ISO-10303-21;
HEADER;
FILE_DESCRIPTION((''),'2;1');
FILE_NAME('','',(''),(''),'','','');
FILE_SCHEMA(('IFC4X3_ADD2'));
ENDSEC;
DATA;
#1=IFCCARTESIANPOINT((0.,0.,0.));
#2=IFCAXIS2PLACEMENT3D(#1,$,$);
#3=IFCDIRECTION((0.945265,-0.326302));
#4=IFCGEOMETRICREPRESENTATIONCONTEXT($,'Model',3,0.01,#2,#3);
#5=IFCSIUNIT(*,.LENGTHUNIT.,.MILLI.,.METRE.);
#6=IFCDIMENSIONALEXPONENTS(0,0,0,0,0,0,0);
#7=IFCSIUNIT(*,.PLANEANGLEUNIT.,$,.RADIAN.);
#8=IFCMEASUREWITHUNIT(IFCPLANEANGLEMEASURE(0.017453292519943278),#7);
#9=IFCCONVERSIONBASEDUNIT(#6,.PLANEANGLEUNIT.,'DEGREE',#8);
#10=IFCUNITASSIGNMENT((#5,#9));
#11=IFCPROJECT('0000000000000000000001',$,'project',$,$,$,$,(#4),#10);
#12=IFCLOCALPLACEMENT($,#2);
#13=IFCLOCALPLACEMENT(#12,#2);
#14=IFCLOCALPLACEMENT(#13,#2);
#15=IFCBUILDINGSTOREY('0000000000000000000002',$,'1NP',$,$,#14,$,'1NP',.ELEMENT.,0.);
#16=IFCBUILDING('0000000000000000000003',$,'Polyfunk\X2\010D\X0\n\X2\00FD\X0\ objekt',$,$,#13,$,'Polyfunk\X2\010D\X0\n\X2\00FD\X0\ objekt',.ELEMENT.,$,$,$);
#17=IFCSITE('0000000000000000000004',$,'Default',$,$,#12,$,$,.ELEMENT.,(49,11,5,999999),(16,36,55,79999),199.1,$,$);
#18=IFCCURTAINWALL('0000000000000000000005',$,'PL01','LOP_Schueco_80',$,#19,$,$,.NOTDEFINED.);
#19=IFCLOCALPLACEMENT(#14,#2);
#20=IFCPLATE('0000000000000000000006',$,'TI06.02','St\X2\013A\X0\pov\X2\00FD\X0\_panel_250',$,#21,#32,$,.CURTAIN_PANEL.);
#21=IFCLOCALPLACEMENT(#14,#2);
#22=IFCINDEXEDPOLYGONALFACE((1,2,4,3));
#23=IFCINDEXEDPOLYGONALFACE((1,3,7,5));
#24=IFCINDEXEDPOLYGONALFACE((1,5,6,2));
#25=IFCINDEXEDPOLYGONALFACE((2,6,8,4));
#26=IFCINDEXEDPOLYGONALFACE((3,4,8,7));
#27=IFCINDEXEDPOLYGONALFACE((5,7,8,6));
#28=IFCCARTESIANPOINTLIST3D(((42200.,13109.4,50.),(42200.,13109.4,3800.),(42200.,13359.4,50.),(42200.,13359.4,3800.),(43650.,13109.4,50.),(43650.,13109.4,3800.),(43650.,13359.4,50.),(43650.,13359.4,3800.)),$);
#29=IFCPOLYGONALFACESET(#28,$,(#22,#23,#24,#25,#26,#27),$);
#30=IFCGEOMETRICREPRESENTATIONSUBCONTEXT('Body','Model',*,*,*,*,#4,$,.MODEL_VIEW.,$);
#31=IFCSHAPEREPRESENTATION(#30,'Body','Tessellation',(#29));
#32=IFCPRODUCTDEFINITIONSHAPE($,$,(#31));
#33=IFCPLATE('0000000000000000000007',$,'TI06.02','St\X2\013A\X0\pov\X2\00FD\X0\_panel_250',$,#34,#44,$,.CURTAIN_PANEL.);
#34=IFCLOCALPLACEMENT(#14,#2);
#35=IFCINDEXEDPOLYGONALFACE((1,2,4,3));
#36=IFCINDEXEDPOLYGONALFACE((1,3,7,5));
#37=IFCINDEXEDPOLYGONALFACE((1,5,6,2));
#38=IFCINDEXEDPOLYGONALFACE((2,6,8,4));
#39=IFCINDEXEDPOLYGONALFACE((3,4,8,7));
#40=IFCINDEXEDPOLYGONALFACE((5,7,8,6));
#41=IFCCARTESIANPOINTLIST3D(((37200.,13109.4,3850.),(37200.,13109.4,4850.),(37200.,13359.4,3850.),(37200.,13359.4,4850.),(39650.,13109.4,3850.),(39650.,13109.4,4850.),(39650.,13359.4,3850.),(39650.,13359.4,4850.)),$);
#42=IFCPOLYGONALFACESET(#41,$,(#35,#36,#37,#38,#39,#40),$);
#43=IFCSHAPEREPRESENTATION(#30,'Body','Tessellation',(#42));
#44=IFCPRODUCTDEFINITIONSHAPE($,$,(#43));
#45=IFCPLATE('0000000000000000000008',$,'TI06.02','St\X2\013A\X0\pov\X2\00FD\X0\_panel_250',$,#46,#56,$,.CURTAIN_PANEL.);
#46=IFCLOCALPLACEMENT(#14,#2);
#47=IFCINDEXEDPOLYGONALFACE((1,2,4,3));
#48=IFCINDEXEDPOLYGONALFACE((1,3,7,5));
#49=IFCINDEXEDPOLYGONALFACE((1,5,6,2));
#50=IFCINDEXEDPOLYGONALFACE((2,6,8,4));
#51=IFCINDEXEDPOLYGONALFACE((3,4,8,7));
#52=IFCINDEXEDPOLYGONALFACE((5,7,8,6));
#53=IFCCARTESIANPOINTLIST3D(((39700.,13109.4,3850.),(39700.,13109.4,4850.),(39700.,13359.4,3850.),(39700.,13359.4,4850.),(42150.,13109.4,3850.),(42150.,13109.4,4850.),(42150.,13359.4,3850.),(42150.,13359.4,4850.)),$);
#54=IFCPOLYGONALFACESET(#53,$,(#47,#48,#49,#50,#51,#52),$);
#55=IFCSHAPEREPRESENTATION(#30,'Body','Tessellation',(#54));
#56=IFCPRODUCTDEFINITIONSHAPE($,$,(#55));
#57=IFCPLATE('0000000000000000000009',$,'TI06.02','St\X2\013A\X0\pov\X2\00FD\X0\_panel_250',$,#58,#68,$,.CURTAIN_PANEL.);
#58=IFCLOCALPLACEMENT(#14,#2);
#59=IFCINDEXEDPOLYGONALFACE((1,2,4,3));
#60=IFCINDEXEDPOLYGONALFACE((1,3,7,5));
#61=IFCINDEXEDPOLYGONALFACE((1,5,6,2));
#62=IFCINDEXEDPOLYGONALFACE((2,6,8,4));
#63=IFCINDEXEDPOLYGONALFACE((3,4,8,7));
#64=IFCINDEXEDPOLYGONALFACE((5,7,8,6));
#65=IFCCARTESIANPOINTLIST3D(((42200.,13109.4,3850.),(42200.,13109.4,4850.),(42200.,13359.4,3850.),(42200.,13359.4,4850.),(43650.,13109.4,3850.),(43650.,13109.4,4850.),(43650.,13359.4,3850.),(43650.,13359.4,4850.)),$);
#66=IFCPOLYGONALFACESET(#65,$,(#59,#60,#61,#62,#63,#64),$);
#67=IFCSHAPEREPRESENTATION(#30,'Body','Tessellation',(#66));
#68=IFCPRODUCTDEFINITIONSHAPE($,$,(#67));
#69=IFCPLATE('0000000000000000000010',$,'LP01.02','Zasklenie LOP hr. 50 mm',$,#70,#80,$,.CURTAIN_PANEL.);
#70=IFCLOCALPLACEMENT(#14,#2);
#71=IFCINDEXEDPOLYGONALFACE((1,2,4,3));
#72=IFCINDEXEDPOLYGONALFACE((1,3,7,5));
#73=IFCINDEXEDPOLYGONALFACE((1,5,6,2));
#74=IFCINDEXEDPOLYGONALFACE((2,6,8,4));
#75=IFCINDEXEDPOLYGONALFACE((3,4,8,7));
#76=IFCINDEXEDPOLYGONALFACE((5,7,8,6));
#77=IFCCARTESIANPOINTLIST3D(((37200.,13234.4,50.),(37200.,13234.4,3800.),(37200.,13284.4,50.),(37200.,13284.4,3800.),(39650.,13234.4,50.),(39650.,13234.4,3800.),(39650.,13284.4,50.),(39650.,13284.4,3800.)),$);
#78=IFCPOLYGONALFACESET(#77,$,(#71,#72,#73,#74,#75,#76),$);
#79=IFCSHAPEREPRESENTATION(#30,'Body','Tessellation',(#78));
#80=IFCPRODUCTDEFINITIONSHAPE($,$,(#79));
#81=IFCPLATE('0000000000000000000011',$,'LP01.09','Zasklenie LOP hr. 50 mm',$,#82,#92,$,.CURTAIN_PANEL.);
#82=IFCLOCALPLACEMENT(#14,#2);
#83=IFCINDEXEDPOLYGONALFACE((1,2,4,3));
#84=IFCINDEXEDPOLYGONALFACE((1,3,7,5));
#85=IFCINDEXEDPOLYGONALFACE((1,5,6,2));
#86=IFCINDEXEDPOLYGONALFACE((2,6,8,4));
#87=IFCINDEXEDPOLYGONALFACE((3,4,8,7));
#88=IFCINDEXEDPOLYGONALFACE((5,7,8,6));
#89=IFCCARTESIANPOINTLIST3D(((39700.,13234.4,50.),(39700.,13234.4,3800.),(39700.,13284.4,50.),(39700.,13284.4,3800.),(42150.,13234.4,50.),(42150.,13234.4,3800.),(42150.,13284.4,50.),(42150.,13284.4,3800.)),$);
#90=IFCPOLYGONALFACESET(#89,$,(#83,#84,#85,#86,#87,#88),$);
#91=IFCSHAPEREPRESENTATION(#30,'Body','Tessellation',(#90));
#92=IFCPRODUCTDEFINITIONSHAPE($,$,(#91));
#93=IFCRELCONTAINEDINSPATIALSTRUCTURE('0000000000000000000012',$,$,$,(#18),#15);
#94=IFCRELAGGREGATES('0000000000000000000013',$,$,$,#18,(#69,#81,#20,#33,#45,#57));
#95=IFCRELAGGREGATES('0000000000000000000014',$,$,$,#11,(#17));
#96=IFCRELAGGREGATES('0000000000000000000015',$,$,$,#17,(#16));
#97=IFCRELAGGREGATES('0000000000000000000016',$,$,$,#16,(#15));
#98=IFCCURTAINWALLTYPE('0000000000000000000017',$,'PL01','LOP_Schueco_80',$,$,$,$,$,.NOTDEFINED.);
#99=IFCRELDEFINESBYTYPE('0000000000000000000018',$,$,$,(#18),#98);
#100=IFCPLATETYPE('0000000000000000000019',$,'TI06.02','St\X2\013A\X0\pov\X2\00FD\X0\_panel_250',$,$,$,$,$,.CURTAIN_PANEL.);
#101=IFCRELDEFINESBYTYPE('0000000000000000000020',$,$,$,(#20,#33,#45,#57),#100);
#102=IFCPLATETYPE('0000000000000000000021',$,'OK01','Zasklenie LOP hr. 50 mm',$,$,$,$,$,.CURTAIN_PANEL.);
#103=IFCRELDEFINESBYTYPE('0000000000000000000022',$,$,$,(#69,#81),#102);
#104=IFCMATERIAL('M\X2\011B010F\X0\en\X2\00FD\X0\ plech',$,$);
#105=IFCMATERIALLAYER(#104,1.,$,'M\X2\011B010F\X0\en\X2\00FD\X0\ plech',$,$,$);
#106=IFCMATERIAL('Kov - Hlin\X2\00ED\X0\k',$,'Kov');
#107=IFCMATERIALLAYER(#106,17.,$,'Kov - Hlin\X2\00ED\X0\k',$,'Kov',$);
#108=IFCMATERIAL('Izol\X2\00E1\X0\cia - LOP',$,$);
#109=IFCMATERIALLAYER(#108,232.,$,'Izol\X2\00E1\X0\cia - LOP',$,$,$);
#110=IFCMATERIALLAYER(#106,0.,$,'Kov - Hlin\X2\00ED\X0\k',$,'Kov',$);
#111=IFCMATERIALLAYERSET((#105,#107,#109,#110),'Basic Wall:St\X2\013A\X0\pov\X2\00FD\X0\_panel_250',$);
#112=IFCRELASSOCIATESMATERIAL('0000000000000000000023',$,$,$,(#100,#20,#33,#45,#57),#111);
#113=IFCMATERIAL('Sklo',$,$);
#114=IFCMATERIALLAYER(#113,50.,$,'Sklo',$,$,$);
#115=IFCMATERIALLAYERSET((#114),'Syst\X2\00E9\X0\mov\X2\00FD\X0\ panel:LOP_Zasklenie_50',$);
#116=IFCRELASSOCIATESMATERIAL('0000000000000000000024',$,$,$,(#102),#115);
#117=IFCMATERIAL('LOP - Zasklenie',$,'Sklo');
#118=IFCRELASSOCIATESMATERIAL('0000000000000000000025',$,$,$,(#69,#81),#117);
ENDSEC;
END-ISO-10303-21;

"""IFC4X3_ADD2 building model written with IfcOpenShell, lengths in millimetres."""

from ifc_helpers import new_model, entity, si_unit, converted_unit, direction, frame, frame_2d, origin, origin_2d_with_axis, place, context, subcontext, project, spatial, rectangle, extrude, source, transform, mapped, material, layer, layer_set, layer_usage, type_object, type_shapes, element, aggregate, save


model = new_model("IFC4X3_ADD2")

# Units and contexts
model_context = context("Model", 3, precision=0.01, world=origin(), true_north=direction((0.945265, -0.326302)))
body_context = subcontext(model_context, "Body", "Model", "MODEL_VIEW")
ifc_project = project(units=[si_unit("LENGTHUNIT", "METRE", prefix="MILLI"), converted_unit("PLANEANGLEUNIT", "DEGREE", entity("IfcPlaneAngleMeasure", 0.017453292519943278), si_unit("PLANEANGLEUNIT", "RADIAN"), dimensions=[0, 0, 0, 0, 0, 0, 0])], contexts=[model_context])

# Site, building, storey
site_placement = place(None, origin())
site = spatial("IfcSite", under=ifc_project, at=site_placement, Name="Default", CompositionType="ELEMENT", RefLatitude=(49, 11, 5, 999999), RefLongitude=(16, 36, 55, 79999), RefElevation=199.1)
building_placement = place(site_placement, origin())
building = spatial("IfcBuilding", under=site, at=building_placement, Name="Polyfunkčný objekt", LongName="Polyfunkčný objekt", CompositionType="ELEMENT")
storey_placement = place(building_placement, origin())
storey = spatial("IfcBuildingStorey", under=building, at=storey_placement, Name="1NP", LongName="1NP", CompositionType="ELEMENT", Elevation=0.0)

# Curtain wall, plates
curtain_wall_type = type_object("IfcCurtainWallType", Name="PL01", Description="LOP_Schueco_80", PredefinedType="NOTDEFINED")
curtain_wall_placement = place(storey_placement, origin())
curtain_wall = element("IfcCurtainWall", 1, at=curtain_wall_placement, inside=storey, type_object=curtain_wall_type, Name="PL01", Description="LOP_Schueco_80", PredefinedType="NOTDEFINED")
ifc_material_1 = material(Name="Měďený plech")
ifc_layer_1 = layer(ifc_material_1, 1.0, Name="Měďený plech")
ifc_material_2 = material(Name="Kov - Hliník", Category="Kov")
ifc_layer_2 = layer(ifc_material_2, 17.0, Name="Kov - Hliník", Category="Kov")
ifc_material_3 = material(Name="Izolácia - LOP")
ifc_layer_3 = layer(ifc_material_3, 232.0, Name="Izolácia - LOP")
ifc_layer_4 = layer(ifc_material_2, 0.0, Name="Kov - Hliník", Category="Kov")
ifc_layer_set_1 = layer_set([ifc_layer_1, ifc_layer_2, ifc_layer_3, ifc_layer_4], Name="Basic Wall:Stĺpový_panel_250")
ifc_layer_usage_1 = layer_usage(ifc_layer_set_1, "AXIS2", "NEGATIVE", 125.0)
plate_type_1 = type_object("IfcPlateType", Name="TI06.02", Description="Stĺpový_panel_250", PredefinedType="CURTAIN_PANEL", material=ifc_layer_set_1)
plate_1_placement = place(storey_placement, frame((42200.0, 13234.4, 50.0)))
plate_1 = element("IfcPlate", 2, at=plate_1_placement, type_object=plate_type_1, material=ifc_layer_usage_1, Name="TI06.02", Description="Stĺpový_panel_250", PredefinedType="CURTAIN_PANEL", context=body_context, shape_type="SweptSolid", body=[
    extrude(rectangle(XDim=250.0, YDim=1450.0, at=frame_2d((0.0, 0.0), x_axis=(1.0, 0.0))), frame((725.0, 0.0, 0.0), z_axis=(0.0, 0.0, 1.0), x_axis=(0.0, 1.0, 0.0)), (0.0, 0.0, 1.0), 3750.0),
])
ifc_layer_usage_2 = layer_usage(ifc_layer_set_1, "AXIS2", "NEGATIVE", 125.0)
plate_2_placement = place(storey_placement, frame((37200.0, 13234.4, 3850.0)))
plate_2 = element("IfcPlate", 3, at=plate_2_placement, type_object=plate_type_1, material=ifc_layer_usage_2, Name="TI06.02", Description="Stĺpový_panel_250", PredefinedType="CURTAIN_PANEL", context=body_context, shape_type="SweptSolid", body=[
    extrude(rectangle(XDim=250.0, YDim=2450.0, at=frame_2d((0.0, 0.0), x_axis=(1.0, 0.0))), frame((1225.0, 0.0, 0.0), z_axis=(0.0, 0.0, 1.0), x_axis=(0.0, 1.0, 0.0)), (0.0, 0.0, 1.0), 1000.0),
])
ifc_layer_usage_3 = layer_usage(ifc_layer_set_1, "AXIS2", "NEGATIVE", 125.0)
plate_3_placement = place(storey_placement, frame((39700.0, 13234.4, 3850.0)))
plate_3 = element("IfcPlate", 4, at=plate_3_placement, type_object=plate_type_1, material=ifc_layer_usage_3, Name="TI06.02", Description="Stĺpový_panel_250", PredefinedType="CURTAIN_PANEL", context=body_context, shape_type="SweptSolid", body=[
    extrude(rectangle(XDim=250.0, YDim=2450.0, at=frame_2d((0.0, 0.0), x_axis=(1.0, 0.0))), frame((1225.0, 0.0, 0.0), z_axis=(0.0, 0.0, 1.0), x_axis=(0.0, 1.0, 0.0)), (0.0, 0.0, 1.0), 1000.0),
])
ifc_layer_usage_4 = layer_usage(ifc_layer_set_1, "AXIS2", "NEGATIVE", 125.0)
plate_4_placement = place(storey_placement, frame((42200.0, 13234.4, 3850.0)))
plate_4 = element("IfcPlate", 5, at=plate_4_placement, type_object=plate_type_1, material=ifc_layer_usage_4, Name="TI06.02", Description="Stĺpový_panel_250", PredefinedType="CURTAIN_PANEL", context=body_context, shape_type="SweptSolid", body=[
    extrude(rectangle(XDim=250.0, YDim=1450.0, at=origin_2d_with_axis()), frame((725.0, 0.0, 0.0), z_axis=(0.0, 0.0, 1.0), x_axis=(0.0, 1.0, 0.0)), (0.0, 0.0, 1.0), 1000.0),
])
ifc_material_4 = material(Name="LOP - Zasklenie", Category="Sklo")
ifc_material_5 = material(Name="Sklo")
ifc_layer_5 = layer(ifc_material_5, 50.0, Name="Sklo")
ifc_layer_set_2 = layer_set([ifc_layer_5], Name="Systémový panel:LOP_Zasklenie_50")
plate_type_2 = type_object("IfcPlateType", Name="OK01", Description="Zasklenie LOP hr. 50 mm", PredefinedType="CURTAIN_PANEL", material=ifc_layer_set_2)
shared_shape_1 = source(origin(), body_context, "Body", "SweptSolid", [
    extrude(rectangle(XDim=3750.0, YDim=2450.0, at=frame_2d((-141.7, 0.0), x_axis=(1.0, 0.0))), frame((0.0, 0.0, 2016.7), z_axis=(0.0, 1.0, 0.0), x_axis=(0.0, 0.0, 1.0)), (0.0, 0.0, 1.0), 50.0),
])
type_shapes(plate_type_2, [shared_shape_1])
plate_5_placement = place(curtain_wall_placement, frame((38425.0, 13234.4, 50.0)))
plate_5 = element("IfcPlate", 6, at=plate_5_placement, type_object=plate_type_2, material=ifc_material_4, Name="LP01.02", Description="Zasklenie LOP hr. 50 mm", PredefinedType="CURTAIN_PANEL", context=body_context, shape_type="MappedRepresentation", body=[
    mapped(shared_shape_1, transform((0.0, 0.0, 0.0), scale=1.0)),
])
plate_6_placement = place(curtain_wall_placement, frame((40925.0, 13234.4, 50.0)))
plate_6 = element("IfcPlate", 7, at=plate_6_placement, type_object=plate_type_2, material=ifc_material_4, Name="LP01.09", Description="Zasklenie LOP hr. 50 mm", PredefinedType="CURTAIN_PANEL", context=body_context, shape_type="MappedRepresentation", body=[
    mapped(shared_shape_1, transform((0.0, 0.0, 0.0), scale=1.0)),
])
aggregate(curtain_wall, [plate_5, plate_6, plate_1, plate_2, plate_3, plate_4])

save(model, "model.ifc")
